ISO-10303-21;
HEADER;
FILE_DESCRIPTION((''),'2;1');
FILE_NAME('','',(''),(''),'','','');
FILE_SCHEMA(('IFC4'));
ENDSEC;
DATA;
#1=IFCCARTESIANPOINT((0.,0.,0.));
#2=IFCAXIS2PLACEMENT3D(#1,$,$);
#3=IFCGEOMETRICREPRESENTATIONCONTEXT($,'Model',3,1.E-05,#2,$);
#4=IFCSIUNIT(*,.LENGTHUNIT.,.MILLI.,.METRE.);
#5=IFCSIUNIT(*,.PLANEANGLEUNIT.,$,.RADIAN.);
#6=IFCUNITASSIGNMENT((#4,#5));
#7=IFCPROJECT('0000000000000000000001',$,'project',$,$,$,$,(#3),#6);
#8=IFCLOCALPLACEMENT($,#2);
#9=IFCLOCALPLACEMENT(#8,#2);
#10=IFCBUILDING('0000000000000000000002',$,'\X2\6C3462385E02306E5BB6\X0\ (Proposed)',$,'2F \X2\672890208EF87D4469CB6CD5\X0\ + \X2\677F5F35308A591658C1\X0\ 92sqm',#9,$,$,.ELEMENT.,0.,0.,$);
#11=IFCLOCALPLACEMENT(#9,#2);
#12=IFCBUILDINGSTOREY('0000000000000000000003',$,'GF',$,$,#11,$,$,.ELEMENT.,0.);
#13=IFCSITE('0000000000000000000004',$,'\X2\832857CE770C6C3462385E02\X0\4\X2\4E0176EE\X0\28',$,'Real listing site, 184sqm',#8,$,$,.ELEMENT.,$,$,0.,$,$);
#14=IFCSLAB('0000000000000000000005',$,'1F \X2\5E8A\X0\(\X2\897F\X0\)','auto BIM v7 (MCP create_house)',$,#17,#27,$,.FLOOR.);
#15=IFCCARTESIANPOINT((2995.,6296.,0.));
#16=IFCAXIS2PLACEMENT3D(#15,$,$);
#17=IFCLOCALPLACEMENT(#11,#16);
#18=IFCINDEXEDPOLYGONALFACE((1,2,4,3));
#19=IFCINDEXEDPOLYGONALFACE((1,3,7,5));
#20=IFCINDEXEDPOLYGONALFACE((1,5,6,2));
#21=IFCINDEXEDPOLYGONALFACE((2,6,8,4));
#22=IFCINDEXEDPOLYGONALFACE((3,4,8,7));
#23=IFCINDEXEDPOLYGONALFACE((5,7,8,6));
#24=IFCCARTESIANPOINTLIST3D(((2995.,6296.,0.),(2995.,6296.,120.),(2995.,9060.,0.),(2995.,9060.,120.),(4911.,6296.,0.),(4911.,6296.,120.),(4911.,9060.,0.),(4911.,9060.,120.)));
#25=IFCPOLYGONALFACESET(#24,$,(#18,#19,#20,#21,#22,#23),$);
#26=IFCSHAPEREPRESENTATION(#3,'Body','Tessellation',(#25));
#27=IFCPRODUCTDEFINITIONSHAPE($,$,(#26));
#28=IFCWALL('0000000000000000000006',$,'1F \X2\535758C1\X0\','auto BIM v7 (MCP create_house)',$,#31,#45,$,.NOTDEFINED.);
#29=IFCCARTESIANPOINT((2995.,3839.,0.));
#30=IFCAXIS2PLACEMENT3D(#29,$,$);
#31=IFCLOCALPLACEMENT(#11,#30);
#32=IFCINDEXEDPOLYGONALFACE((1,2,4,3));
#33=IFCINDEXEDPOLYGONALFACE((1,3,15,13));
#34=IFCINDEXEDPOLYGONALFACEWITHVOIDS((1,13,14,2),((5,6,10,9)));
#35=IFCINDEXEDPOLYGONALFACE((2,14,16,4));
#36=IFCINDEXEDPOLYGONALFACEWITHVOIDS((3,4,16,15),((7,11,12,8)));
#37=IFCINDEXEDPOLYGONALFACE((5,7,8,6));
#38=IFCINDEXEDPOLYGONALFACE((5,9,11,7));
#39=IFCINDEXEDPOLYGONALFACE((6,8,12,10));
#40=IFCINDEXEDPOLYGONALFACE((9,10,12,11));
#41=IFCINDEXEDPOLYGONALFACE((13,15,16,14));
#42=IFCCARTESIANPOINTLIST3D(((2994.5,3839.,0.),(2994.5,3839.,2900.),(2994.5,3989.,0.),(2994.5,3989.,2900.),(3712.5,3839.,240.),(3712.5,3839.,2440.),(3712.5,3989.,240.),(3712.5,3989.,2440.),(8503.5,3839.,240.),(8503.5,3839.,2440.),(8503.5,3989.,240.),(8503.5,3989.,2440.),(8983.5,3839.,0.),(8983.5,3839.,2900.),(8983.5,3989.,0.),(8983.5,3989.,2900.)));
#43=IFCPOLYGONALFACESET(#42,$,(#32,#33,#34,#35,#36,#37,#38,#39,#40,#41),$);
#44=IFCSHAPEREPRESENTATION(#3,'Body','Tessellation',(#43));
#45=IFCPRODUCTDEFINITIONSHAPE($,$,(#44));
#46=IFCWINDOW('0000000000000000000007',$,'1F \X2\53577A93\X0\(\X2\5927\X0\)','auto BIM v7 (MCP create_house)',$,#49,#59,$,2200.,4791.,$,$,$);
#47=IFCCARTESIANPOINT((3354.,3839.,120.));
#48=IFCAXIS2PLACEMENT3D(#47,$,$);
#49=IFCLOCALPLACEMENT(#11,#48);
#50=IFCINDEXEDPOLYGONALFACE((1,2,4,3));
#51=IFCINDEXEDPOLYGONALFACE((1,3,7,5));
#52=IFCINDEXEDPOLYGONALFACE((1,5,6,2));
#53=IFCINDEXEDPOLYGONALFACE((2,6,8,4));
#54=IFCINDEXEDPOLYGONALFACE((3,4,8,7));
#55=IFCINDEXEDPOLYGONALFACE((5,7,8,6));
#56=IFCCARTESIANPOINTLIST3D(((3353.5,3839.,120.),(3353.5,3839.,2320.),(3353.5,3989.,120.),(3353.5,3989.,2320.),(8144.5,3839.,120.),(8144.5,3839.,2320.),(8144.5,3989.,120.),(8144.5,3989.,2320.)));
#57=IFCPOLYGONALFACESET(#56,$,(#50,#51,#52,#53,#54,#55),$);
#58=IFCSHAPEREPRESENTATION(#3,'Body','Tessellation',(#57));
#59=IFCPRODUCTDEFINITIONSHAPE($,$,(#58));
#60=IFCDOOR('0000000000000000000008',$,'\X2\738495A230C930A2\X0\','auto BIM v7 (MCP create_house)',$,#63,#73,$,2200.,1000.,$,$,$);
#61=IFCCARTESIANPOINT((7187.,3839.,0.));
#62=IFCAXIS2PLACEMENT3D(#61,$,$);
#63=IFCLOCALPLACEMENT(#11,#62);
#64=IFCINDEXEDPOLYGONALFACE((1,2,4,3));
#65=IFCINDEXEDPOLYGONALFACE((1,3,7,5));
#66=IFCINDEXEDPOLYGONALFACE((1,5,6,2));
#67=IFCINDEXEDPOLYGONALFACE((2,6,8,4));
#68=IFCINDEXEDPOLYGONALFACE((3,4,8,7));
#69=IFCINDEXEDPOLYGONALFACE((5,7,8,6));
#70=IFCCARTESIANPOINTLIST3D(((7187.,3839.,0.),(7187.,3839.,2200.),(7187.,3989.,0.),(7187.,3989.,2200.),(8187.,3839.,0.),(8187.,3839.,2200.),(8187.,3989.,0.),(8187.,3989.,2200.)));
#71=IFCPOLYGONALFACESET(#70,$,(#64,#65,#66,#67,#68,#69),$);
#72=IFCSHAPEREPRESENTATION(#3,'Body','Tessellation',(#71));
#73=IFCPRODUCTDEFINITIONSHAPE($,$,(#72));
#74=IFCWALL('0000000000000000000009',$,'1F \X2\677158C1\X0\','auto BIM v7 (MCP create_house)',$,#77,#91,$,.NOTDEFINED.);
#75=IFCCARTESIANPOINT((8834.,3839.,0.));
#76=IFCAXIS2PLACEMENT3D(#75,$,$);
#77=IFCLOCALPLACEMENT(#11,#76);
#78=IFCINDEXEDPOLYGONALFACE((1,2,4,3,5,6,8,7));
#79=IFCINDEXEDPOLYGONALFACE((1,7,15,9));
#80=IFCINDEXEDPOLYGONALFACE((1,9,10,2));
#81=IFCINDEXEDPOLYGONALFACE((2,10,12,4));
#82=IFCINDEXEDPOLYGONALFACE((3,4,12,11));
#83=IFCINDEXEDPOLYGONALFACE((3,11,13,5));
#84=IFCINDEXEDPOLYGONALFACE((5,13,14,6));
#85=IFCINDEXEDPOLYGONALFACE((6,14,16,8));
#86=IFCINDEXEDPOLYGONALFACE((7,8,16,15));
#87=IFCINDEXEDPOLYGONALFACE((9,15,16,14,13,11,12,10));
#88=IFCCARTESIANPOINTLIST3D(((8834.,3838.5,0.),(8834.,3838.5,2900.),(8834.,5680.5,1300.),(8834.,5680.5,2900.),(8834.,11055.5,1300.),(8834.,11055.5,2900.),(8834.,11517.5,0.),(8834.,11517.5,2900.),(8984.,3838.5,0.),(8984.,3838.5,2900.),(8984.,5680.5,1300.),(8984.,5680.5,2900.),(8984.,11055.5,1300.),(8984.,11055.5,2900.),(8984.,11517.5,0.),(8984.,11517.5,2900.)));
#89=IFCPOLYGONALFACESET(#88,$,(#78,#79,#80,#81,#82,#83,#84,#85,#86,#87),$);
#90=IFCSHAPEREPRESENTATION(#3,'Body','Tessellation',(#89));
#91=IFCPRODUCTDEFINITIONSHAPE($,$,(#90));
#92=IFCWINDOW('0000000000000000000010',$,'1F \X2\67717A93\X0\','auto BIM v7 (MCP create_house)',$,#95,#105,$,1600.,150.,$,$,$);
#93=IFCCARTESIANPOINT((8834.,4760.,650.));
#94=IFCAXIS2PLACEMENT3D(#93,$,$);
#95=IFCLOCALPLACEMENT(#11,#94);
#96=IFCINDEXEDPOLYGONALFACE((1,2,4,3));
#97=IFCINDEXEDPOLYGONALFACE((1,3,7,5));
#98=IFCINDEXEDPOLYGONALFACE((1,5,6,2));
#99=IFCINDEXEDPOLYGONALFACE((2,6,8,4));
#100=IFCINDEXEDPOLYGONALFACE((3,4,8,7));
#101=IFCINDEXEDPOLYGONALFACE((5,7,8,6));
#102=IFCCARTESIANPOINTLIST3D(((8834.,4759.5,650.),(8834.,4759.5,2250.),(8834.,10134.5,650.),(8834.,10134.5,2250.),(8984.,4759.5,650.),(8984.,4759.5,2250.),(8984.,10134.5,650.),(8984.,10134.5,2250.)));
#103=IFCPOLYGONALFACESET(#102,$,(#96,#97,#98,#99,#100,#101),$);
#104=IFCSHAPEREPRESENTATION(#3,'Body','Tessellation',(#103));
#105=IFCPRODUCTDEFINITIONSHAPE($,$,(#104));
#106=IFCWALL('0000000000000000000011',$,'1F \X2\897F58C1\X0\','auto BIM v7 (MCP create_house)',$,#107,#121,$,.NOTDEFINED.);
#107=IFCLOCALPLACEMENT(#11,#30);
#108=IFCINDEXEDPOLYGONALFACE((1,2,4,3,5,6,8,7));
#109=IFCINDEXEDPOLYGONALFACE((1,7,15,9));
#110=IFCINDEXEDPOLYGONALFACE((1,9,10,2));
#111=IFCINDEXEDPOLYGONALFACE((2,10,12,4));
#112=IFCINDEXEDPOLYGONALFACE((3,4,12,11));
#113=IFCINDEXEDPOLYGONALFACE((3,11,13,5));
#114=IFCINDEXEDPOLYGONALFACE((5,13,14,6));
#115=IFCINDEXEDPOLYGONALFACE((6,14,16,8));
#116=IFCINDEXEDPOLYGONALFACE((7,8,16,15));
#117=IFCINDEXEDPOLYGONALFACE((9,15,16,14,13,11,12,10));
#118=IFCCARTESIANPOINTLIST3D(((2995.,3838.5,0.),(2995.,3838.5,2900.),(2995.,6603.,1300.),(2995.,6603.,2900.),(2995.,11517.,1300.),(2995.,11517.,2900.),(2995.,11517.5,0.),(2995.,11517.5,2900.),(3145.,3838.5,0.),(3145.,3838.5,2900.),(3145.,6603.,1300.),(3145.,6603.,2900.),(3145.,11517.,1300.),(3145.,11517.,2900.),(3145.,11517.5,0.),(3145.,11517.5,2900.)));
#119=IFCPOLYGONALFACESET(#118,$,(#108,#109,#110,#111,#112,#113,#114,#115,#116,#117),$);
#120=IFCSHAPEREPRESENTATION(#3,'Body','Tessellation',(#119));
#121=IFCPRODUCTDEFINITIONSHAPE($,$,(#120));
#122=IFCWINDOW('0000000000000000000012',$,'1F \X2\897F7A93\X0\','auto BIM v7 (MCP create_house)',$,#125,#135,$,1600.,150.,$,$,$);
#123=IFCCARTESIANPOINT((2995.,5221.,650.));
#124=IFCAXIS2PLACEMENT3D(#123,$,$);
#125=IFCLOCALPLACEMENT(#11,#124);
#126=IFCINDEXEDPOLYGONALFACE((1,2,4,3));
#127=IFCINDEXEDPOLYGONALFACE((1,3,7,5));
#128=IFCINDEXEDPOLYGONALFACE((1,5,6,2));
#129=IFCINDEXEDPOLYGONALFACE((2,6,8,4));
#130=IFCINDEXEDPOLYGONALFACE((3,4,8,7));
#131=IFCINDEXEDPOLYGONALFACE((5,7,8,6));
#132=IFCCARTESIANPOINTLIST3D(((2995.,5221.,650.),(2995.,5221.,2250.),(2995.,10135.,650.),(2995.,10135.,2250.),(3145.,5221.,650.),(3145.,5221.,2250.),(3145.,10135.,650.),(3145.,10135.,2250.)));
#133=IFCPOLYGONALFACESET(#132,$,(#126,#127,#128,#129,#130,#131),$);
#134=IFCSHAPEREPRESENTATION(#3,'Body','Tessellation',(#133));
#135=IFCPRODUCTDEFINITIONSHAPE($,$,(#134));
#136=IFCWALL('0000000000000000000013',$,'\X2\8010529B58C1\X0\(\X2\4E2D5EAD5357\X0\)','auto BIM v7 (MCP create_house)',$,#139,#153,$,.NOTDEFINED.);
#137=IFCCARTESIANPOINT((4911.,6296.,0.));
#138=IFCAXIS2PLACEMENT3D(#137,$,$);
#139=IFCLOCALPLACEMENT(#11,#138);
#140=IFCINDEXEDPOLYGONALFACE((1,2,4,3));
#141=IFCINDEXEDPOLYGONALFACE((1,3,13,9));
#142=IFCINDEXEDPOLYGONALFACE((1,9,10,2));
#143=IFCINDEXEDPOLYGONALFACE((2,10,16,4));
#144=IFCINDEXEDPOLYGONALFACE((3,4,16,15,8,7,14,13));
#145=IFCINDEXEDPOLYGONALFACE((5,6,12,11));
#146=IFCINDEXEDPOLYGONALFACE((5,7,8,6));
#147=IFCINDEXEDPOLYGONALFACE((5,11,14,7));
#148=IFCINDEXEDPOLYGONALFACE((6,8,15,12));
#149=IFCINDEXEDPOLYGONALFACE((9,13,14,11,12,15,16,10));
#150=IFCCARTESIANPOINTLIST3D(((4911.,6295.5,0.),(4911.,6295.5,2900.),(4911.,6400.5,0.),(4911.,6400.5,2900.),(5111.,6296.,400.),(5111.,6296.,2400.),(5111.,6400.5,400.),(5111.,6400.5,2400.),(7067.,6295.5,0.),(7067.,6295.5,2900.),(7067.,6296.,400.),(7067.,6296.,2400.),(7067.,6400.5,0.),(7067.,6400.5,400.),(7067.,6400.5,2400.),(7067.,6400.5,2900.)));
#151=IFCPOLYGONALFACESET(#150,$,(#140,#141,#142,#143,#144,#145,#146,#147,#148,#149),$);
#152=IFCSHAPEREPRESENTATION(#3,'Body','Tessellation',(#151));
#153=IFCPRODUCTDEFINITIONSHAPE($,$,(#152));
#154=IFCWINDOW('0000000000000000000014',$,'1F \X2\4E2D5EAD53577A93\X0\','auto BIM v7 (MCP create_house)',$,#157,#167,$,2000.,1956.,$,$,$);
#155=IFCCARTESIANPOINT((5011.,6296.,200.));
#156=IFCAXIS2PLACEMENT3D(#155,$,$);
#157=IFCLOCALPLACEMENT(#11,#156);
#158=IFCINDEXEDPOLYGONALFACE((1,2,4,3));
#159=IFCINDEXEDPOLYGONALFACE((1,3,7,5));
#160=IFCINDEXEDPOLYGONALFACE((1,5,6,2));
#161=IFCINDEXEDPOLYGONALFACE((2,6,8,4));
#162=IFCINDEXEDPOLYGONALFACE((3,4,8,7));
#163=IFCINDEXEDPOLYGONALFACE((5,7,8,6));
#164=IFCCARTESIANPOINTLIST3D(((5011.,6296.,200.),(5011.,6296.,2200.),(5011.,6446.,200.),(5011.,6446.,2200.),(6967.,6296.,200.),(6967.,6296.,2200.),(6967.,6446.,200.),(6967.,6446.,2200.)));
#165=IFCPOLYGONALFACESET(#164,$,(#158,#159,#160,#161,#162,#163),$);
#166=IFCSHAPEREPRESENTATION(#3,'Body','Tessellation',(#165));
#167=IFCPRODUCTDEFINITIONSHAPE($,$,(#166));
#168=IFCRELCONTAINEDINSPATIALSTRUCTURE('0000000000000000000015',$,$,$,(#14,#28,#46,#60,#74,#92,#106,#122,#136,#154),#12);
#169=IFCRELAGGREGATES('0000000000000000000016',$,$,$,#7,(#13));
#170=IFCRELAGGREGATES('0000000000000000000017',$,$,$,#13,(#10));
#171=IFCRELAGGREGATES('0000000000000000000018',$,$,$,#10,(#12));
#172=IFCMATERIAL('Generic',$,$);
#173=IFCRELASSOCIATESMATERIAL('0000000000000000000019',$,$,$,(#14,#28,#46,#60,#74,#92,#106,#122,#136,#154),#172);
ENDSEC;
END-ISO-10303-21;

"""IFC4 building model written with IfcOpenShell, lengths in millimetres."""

from ifc_helpers import new_model, si_unit, frame, frame_2d, origin, place, context, project, spatial, rectangle, extrude, material, element, fill, save


model = new_model("IFC4")

# Units and contexts
model_context = context("Model", 3, precision=1e-05, world=origin())
ifc_project = project(units=[si_unit("LENGTHUNIT", "METRE", prefix="MILLI"), si_unit("PLANEANGLEUNIT", "RADIAN")], contexts=[model_context])

# Site, building, storey
site_placement = place(None, origin())
site = spatial("IfcSite", under=ifc_project, at=site_placement, Name="茨城県水戸市4丁目28", ObjectType="Real listing site, 184sqm", CompositionType="ELEMENT", RefElevation=0.0)
building_placement = place(site_placement, origin())
building = spatial("IfcBuilding", under=site, at=building_placement, Name="水戸市の家 (Proposed)", ObjectType="2F 木造軸組構法 + 板張り外壁 92sqm", CompositionType="ELEMENT", ElevationOfRefHeight=0.0, ElevationOfTerrain=0.0)
storey_placement = place(building_placement, origin())
storey = spatial("IfcBuildingStorey", under=building, at=storey_placement, Name="GF", CompositionType="ELEMENT", Elevation=0.0)

# Slab
ifc_material = material(Name="Generic")
slab_1_placement = place(storey_placement, frame((2995.0, 6296.0, 0.0)))
element("IfcSlab", 1, at=slab_1_placement, inside=storey, material=ifc_material, Name="1F 床(西)", Description="auto BIM v7 (MCP create_house)", PredefinedType="FLOOR", context=model_context, shape_type="SweptSolid", body=[
    extrude(rectangle(XDim=1916.0, YDim=2764.0, at=frame_2d((958.0, 1382.0))), frame((2995.0, 6296.0, 0.0)), (0.0, 0.0, 1.0), 120.0),
])

# Wall, openings, window, door
wall_1_placement = place(storey_placement, frame((2995.0, 3839.0, 0.0)))
wall_1 = element("IfcWall", 2, at=wall_1_placement, inside=storey, material=ifc_material, Name="1F 南壁", Description="auto BIM v7 (MCP create_house)", PredefinedType="NOTDEFINED", context=model_context, shape_type="SweptSolid", body=[
    extrude(rectangle(XDim=5989.0, YDim=150.0, at=frame_2d((2994.0, 75.0))), frame((2995.0, 3839.0, 0.0)), (0.0, 0.0, 1.0), 2900.0),
])
opening_1_placement = place(storey_placement, frame((3354.0, 3839.0, 120.0)))
opening_1 = element("IfcOpeningElement", 3, at=opening_1_placement, cuts=wall_1, PredefinedType="NOTDEFINED", context=model_context, shape_type="SweptSolid", body=[
    extrude(rectangle(XDim=4791.0, YDim=150.0, at=frame_2d((2395.0, 75.0))), frame((3354.0, 3839.0, 120.0)), (0.0, 0.0, 1.0), 2200.0),
])
opening_2_placement = place(storey_placement, frame((7187.0, 3839.0, 0.0)))
opening_2 = element("IfcOpeningElement", 4, at=opening_2_placement, cuts=wall_1, PredefinedType="NOTDEFINED", context=model_context, shape_type="SweptSolid", body=[
    extrude(rectangle(XDim=1000.0, YDim=150.0, at=frame_2d((500.0, 75.0))), frame((7187.0, 3839.0, 0.0)), (0.0, 0.0, 1.0), 2200.0),
])
window_1_placement = place(storey_placement, frame((3354.0, 3839.0, 120.0)))
window_1 = element("IfcWindow", 5, at=window_1_placement, inside=storey, material=ifc_material, Name="1F 南窓(大)", Description="auto BIM v7 (MCP create_house)", OverallHeight=2200.0, OverallWidth=4791.0, context=model_context, shape_type="SweptSolid", body=[
    extrude(rectangle(XDim=4791.0, YDim=150.0, at=frame_2d((2395.0, 75.0))), frame((3354.0, 3839.0, 120.0)), (0.0, 0.0, 1.0), 2200.0),
])
fill(opening_1, window_1)
door_placement = place(storey_placement, frame((7187.0, 3839.0, 0.0)))
door = element("IfcDoor", 6, at=door_placement, inside=storey, material=ifc_material, Name="玄関ドア", Description="auto BIM v7 (MCP create_house)", OverallHeight=2200.0, OverallWidth=1000.0, context=model_context, shape_type="SweptSolid", body=[
    extrude(rectangle(XDim=1000.0, YDim=150.0, at=frame_2d((500.0, 75.0))), frame((7187.0, 3839.0, 0.0)), (0.0, 0.0, 1.0), 2200.0),
])
fill(opening_2, door)

# Walls, openings, windows
wall_2_placement = place(storey_placement, frame((8834.0, 3839.0, 0.0)))
wall_2 = element("IfcWall", 7, at=wall_2_placement, inside=storey, material=ifc_material, Name="1F 東壁", Description="auto BIM v7 (MCP create_house)", PredefinedType="NOTDEFINED", context=model_context, shape_type="SweptSolid", body=[
    extrude(rectangle(XDim=150.0, YDim=7679.0, at=frame_2d((75.0, 3839.0))), frame((8834.0, 3839.0, 0.0)), (0.0, 0.0, 1.0), 2900.0),
])
opening_3_placement = place(storey_placement, frame((8834.0, 4760.0, 650.0)))
opening_3 = element("IfcOpeningElement", 8, at=opening_3_placement, cuts=wall_2, PredefinedType="NOTDEFINED", context=model_context, shape_type="SweptSolid", body=[
    extrude(rectangle(XDim=150.0, YDim=5375.0, at=frame_2d((75.0, 2687.0))), frame((8834.0, 4760.0, 650.0)), (0.0, 0.0, 1.0), 1600.0),
])
window_2_placement = place(storey_placement, frame((8834.0, 4760.0, 650.0)))
window_2 = element("IfcWindow", 9, at=window_2_placement, inside=storey, material=ifc_material, Name="1F 東窓", Description="auto BIM v7 (MCP create_house)", OverallHeight=1600.0, OverallWidth=150.0, context=model_context, shape_type="SweptSolid", body=[
    extrude(rectangle(XDim=150.0, YDim=5375.0, at=frame_2d((75.0, 2687.0))), frame((8834.0, 4760.0, 650.0)), (0.0, 0.0, 1.0), 1600.0),
])
fill(opening_3, window_2)
wall_3_placement = place(storey_placement, frame((2995.0, 3839.0, 0.0)))
wall_3 = element("IfcWall", 10, at=wall_3_placement, inside=storey, material=ifc_material, Name="1F 西壁", Description="auto BIM v7 (MCP create_house)", PredefinedType="NOTDEFINED", context=model_context, shape_type="SweptSolid", body=[
    extrude(rectangle(XDim=150.0, YDim=7679.0, at=frame_2d((75.0, 3839.0))), frame((2995.0, 3839.0, 0.0)), (0.0, 0.0, 1.0), 2900.0),
])
opening_4_placement = place(storey_placement, frame((2995.0, 5221.0, 650.0)))
opening_4 = element("IfcOpeningElement", 11, at=opening_4_placement, cuts=wall_3, PredefinedType="NOTDEFINED", context=model_context, shape_type="SweptSolid", body=[
    extrude(rectangle(XDim=150.0, YDim=4914.0, at=frame_2d((75.0, 2457.0))), frame((2995.0, 5221.0, 650.0)), (0.0, 0.0, 1.0), 1600.0),
])
window_3_placement = place(storey_placement, frame((2995.0, 5221.0, 650.0)))
window_3 = element("IfcWindow", 12, at=window_3_placement, inside=storey, material=ifc_material, Name="1F 西窓", Description="auto BIM v7 (MCP create_house)", OverallHeight=1600.0, OverallWidth=150.0, context=model_context, shape_type="SweptSolid", body=[
    extrude(rectangle(XDim=150.0, YDim=4914.0, at=frame_2d((75.0, 2457.0))), frame((2995.0, 5221.0, 650.0)), (0.0, 0.0, 1.0), 1600.0),
])
fill(opening_4, window_3)
wall_4_placement = place(storey_placement, frame((4911.0, 6296.0, 0.0)))
wall_4 = element("IfcWall", 13, at=wall_4_placement, inside=storey, material=ifc_material, Name="耐力壁(中庭南)", Description="auto BIM v7 (MCP create_house)", PredefinedType="NOTDEFINED", context=model_context, shape_type="SweptSolid", body=[
    extrude(rectangle(XDim=2156.0, YDim=105.0, at=frame_2d((1078.0, 52.0))), frame((4911.0, 6296.0, 0.0)), (0.0, 0.0, 1.0), 2900.0),
])
opening_5_placement = place(storey_placement, frame((5011.0, 6296.0, 200.0)))
opening_5 = element("IfcOpeningElement", 14, at=opening_5_placement, cuts=wall_4, PredefinedType="NOTDEFINED", context=model_context, shape_type="SweptSolid", body=[
    extrude(rectangle(XDim=1956.0, YDim=150.0, at=frame_2d((978.0, 75.0))), frame((5011.0, 6296.0, 200.0)), (0.0, 0.0, 1.0), 2000.0),
])
window_4_placement = place(storey_placement, frame((5011.0, 6296.0, 200.0)))
window_4 = element("IfcWindow", 15, at=window_4_placement, inside=storey, material=ifc_material, Name="1F 中庭南窓", Description="auto BIM v7 (MCP create_house)", OverallHeight=2000.0, OverallWidth=1956.0, context=model_context, shape_type="SweptSolid", body=[
    extrude(rectangle(XDim=1956.0, YDim=150.0, at=frame_2d((978.0, 75.0))), frame((5011.0, 6296.0, 200.0)), (0.0, 0.0, 1.0), 2000.0),
])
fill(opening_5, window_4)

save(model, "model.ifc")
